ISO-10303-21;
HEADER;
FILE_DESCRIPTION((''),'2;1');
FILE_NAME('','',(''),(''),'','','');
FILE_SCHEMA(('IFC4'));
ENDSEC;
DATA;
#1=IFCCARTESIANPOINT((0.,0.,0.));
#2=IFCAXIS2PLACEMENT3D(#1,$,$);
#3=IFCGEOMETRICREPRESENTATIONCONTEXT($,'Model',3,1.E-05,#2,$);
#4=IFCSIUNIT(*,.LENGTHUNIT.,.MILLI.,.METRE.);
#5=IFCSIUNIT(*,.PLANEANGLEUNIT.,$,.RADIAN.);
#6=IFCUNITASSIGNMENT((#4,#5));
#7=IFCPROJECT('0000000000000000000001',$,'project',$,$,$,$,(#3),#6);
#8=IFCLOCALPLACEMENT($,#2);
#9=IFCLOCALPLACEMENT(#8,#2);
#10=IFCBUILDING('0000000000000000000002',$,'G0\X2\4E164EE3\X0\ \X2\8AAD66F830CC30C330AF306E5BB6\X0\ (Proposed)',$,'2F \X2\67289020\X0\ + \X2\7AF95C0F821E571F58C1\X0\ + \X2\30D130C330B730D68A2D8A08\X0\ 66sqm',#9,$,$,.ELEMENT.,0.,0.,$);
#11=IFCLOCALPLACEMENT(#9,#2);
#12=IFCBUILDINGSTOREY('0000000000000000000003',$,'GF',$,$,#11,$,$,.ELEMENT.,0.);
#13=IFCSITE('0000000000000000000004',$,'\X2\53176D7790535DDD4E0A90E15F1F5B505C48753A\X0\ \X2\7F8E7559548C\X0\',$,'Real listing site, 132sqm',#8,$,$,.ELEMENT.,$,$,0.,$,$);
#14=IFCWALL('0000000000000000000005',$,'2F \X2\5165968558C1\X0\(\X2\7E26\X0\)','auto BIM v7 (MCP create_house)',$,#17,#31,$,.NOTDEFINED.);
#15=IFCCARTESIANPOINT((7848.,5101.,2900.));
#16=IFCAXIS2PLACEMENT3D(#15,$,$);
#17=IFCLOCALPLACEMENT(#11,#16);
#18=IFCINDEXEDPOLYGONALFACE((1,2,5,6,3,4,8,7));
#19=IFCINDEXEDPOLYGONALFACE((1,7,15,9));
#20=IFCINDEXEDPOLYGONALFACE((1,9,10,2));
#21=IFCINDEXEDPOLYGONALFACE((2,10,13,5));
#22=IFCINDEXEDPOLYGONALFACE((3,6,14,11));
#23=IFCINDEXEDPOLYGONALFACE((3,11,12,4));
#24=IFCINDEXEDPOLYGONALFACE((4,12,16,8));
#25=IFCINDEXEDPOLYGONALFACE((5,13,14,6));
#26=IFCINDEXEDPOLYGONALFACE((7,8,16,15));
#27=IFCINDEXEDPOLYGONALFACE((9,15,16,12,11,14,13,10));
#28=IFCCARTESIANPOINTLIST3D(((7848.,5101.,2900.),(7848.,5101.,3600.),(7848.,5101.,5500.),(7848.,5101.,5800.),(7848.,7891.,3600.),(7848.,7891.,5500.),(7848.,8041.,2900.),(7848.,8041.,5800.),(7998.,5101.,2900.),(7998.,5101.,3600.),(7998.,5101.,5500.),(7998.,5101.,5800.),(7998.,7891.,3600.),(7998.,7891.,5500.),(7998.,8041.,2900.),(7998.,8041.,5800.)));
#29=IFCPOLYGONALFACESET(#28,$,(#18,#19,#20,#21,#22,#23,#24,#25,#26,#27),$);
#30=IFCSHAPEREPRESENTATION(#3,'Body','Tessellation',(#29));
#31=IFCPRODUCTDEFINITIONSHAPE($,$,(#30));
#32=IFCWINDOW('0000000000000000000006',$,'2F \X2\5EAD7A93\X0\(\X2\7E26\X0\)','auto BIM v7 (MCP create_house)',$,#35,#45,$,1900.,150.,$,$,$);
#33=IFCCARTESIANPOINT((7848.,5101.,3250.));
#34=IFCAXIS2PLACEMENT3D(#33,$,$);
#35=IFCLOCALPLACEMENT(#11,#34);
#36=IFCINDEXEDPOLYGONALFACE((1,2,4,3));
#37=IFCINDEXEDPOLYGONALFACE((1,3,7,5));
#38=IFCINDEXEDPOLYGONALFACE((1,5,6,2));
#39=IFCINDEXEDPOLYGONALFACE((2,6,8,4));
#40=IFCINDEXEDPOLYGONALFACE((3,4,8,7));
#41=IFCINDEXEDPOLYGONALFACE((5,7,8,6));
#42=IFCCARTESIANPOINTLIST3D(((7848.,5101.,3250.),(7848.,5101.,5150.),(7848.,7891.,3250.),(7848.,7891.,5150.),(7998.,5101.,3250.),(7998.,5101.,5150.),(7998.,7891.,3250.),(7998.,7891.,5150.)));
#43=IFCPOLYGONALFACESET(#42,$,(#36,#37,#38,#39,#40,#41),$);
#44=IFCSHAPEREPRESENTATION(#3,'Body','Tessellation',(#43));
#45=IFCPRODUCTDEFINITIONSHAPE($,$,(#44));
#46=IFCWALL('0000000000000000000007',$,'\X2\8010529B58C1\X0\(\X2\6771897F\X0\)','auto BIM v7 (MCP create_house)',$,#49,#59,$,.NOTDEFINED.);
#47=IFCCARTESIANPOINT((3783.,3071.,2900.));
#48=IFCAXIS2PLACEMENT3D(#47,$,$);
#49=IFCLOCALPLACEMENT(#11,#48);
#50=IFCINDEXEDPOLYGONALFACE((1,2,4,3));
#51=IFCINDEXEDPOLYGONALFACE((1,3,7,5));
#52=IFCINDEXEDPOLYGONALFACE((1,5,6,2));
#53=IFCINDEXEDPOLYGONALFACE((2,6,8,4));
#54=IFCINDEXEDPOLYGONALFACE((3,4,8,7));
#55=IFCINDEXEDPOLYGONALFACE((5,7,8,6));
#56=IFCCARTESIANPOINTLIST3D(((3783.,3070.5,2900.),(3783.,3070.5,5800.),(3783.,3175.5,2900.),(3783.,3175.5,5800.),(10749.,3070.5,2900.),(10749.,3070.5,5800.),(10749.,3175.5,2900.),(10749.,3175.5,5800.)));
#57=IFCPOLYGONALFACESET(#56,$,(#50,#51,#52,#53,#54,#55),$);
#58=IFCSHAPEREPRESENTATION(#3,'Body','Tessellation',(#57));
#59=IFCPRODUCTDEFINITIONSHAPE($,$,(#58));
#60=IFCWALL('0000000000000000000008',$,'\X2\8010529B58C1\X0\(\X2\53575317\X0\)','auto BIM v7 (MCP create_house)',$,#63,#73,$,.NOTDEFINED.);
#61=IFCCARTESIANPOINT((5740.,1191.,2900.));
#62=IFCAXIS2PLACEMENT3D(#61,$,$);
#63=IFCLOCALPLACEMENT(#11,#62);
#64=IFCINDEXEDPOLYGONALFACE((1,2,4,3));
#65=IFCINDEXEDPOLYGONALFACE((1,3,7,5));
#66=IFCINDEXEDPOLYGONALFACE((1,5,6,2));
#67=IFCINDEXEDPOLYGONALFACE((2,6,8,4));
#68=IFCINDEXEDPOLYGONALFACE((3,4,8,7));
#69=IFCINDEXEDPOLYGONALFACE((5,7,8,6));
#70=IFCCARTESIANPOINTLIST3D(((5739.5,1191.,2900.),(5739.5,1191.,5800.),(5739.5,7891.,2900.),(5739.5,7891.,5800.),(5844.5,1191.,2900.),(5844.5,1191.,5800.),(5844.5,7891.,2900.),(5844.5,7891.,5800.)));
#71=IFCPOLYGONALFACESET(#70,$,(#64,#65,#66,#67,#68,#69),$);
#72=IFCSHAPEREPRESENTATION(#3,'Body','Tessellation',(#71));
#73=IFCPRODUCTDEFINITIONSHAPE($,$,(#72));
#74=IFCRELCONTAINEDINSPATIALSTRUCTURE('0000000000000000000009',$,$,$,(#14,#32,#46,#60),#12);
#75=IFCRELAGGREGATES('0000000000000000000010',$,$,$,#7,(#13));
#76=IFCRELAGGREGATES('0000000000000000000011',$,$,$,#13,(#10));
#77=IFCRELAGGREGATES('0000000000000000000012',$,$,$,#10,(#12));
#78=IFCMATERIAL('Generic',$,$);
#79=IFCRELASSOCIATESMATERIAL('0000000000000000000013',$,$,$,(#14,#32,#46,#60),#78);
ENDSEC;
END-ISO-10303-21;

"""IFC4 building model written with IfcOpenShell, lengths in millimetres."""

from ifc_helpers import new_model, si_unit, frame, frame_2d, origin, place, context, project, spatial, rectangle, extrude, material, element, fill, save


model = new_model("IFC4")

# Units and contexts
model_context = context("Model", 3, precision=1e-05, world=origin())
ifc_project = project(units=[si_unit("LENGTHUNIT", "METRE", prefix="MILLI"), si_unit("PLANEANGLEUNIT", "RADIAN")], contexts=[model_context])

# Site, building, storey
site_placement = place(None, origin())
site = spatial("IfcSite", under=ifc_project, at=site_placement, Name="北海道川上郡弟子屈町 美留和", ObjectType="Real listing site, 132sqm", CompositionType="ELEMENT", RefElevation=0.0)
building_placement = place(site_placement, origin())
building = spatial("IfcBuilding", under=site, at=building_placement, Name="G0世代 読書ヌックの家 (Proposed)", ObjectType="2F 木造 + 竹小舞土壁 + パッシブ設計 66sqm", CompositionType="ELEMENT", ElevationOfRefHeight=0.0, ElevationOfTerrain=0.0)
storey_placement = place(building_placement, origin())
storey = spatial("IfcBuildingStorey", under=building, at=storey_placement, Name="GF", CompositionType="ELEMENT", Elevation=0.0)

# Shared definitions
ifc_material = material(Name="Generic")

# Wall, opening, window
wall_1_placement = place(storey_placement, frame((7848.0, 5101.0, 2900.0)))
wall_1 = element("IfcWall", 1, at=wall_1_placement, inside=storey, material=ifc_material, Name="2F 入隅壁(縦)", Description="auto BIM v7 (MCP create_house)", PredefinedType="NOTDEFINED", context=model_context, shape_type="SweptSolid", body=[
    extrude(rectangle(XDim=150.0, YDim=2940.0, at=frame_2d((75.0, 1470.0))), frame((7848.0, 5101.0, 2900.0)), (0.0, 0.0, 1.0), 2900.0),
])
opening_1_placement = place(storey_placement, frame((7848.0, 5101.0, 3250.0)))
opening_1 = element("IfcOpeningElement", 2, at=opening_1_placement, cuts=wall_1, PredefinedType="NOTDEFINED", context=model_context, shape_type="SweptSolid", body=[
    extrude(rectangle(XDim=150.0, YDim=2790.0, at=frame_2d((75.0, 1395.0))), frame((7848.0, 5101.0, 3250.0)), (0.0, 0.0, 1.0), 1900.0),
])
window_1_placement = place(storey_placement, frame((7848.0, 5101.0, 3250.0)))
window_1 = element("IfcWindow", 3, at=window_1_placement, inside=storey, material=ifc_material, Name="2F 庭窓(縦)", Description="auto BIM v7 (MCP create_house)", OverallHeight=1900.0, OverallWidth=150.0, context=model_context, shape_type="SweptSolid", body=[
    extrude(rectangle(XDim=150.0, YDim=2790.0, at=frame_2d((75.0, 1395.0))), frame((7848.0, 5101.0, 3250.0)), (0.0, 0.0, 1.0), 1900.0),
])
fill(opening_1, window_1)

# Walls
wall_2_placement = place(storey_placement, frame((3783.0, 3071.0, 2900.0)))
element("IfcWall", 4, at=wall_2_placement, inside=storey, material=ifc_material, Name="耐力壁(東西)", Description="auto BIM v7 (MCP create_house)", PredefinedType="NOTDEFINED", context=model_context, shape_type="SweptSolid", body=[
    extrude(rectangle(XDim=6966.0, YDim=105.0, at=frame_2d((3483.0, 52.0))), frame((3783.0, 3071.0, 2900.0)), (0.0, 0.0, 1.0), 2900.0),
])
wall_3_placement = place(storey_placement, frame((5740.0, 1191.0, 2900.0)))
element("IfcWall", 5, at=wall_3_placement, inside=storey, material=ifc_material, Name="耐力壁(南北)", Description="auto BIM v7 (MCP create_house)", PredefinedType="NOTDEFINED", context=model_context, shape_type="SweptSolid", body=[
    extrude(rectangle(XDim=105.0, YDim=6700.0, at=frame_2d((52.0, 3350.0))), frame((5740.0, 1191.0, 2900.0)), (0.0, 0.0, 1.0), 2900.0),
])

save(model, "model.ifc")
